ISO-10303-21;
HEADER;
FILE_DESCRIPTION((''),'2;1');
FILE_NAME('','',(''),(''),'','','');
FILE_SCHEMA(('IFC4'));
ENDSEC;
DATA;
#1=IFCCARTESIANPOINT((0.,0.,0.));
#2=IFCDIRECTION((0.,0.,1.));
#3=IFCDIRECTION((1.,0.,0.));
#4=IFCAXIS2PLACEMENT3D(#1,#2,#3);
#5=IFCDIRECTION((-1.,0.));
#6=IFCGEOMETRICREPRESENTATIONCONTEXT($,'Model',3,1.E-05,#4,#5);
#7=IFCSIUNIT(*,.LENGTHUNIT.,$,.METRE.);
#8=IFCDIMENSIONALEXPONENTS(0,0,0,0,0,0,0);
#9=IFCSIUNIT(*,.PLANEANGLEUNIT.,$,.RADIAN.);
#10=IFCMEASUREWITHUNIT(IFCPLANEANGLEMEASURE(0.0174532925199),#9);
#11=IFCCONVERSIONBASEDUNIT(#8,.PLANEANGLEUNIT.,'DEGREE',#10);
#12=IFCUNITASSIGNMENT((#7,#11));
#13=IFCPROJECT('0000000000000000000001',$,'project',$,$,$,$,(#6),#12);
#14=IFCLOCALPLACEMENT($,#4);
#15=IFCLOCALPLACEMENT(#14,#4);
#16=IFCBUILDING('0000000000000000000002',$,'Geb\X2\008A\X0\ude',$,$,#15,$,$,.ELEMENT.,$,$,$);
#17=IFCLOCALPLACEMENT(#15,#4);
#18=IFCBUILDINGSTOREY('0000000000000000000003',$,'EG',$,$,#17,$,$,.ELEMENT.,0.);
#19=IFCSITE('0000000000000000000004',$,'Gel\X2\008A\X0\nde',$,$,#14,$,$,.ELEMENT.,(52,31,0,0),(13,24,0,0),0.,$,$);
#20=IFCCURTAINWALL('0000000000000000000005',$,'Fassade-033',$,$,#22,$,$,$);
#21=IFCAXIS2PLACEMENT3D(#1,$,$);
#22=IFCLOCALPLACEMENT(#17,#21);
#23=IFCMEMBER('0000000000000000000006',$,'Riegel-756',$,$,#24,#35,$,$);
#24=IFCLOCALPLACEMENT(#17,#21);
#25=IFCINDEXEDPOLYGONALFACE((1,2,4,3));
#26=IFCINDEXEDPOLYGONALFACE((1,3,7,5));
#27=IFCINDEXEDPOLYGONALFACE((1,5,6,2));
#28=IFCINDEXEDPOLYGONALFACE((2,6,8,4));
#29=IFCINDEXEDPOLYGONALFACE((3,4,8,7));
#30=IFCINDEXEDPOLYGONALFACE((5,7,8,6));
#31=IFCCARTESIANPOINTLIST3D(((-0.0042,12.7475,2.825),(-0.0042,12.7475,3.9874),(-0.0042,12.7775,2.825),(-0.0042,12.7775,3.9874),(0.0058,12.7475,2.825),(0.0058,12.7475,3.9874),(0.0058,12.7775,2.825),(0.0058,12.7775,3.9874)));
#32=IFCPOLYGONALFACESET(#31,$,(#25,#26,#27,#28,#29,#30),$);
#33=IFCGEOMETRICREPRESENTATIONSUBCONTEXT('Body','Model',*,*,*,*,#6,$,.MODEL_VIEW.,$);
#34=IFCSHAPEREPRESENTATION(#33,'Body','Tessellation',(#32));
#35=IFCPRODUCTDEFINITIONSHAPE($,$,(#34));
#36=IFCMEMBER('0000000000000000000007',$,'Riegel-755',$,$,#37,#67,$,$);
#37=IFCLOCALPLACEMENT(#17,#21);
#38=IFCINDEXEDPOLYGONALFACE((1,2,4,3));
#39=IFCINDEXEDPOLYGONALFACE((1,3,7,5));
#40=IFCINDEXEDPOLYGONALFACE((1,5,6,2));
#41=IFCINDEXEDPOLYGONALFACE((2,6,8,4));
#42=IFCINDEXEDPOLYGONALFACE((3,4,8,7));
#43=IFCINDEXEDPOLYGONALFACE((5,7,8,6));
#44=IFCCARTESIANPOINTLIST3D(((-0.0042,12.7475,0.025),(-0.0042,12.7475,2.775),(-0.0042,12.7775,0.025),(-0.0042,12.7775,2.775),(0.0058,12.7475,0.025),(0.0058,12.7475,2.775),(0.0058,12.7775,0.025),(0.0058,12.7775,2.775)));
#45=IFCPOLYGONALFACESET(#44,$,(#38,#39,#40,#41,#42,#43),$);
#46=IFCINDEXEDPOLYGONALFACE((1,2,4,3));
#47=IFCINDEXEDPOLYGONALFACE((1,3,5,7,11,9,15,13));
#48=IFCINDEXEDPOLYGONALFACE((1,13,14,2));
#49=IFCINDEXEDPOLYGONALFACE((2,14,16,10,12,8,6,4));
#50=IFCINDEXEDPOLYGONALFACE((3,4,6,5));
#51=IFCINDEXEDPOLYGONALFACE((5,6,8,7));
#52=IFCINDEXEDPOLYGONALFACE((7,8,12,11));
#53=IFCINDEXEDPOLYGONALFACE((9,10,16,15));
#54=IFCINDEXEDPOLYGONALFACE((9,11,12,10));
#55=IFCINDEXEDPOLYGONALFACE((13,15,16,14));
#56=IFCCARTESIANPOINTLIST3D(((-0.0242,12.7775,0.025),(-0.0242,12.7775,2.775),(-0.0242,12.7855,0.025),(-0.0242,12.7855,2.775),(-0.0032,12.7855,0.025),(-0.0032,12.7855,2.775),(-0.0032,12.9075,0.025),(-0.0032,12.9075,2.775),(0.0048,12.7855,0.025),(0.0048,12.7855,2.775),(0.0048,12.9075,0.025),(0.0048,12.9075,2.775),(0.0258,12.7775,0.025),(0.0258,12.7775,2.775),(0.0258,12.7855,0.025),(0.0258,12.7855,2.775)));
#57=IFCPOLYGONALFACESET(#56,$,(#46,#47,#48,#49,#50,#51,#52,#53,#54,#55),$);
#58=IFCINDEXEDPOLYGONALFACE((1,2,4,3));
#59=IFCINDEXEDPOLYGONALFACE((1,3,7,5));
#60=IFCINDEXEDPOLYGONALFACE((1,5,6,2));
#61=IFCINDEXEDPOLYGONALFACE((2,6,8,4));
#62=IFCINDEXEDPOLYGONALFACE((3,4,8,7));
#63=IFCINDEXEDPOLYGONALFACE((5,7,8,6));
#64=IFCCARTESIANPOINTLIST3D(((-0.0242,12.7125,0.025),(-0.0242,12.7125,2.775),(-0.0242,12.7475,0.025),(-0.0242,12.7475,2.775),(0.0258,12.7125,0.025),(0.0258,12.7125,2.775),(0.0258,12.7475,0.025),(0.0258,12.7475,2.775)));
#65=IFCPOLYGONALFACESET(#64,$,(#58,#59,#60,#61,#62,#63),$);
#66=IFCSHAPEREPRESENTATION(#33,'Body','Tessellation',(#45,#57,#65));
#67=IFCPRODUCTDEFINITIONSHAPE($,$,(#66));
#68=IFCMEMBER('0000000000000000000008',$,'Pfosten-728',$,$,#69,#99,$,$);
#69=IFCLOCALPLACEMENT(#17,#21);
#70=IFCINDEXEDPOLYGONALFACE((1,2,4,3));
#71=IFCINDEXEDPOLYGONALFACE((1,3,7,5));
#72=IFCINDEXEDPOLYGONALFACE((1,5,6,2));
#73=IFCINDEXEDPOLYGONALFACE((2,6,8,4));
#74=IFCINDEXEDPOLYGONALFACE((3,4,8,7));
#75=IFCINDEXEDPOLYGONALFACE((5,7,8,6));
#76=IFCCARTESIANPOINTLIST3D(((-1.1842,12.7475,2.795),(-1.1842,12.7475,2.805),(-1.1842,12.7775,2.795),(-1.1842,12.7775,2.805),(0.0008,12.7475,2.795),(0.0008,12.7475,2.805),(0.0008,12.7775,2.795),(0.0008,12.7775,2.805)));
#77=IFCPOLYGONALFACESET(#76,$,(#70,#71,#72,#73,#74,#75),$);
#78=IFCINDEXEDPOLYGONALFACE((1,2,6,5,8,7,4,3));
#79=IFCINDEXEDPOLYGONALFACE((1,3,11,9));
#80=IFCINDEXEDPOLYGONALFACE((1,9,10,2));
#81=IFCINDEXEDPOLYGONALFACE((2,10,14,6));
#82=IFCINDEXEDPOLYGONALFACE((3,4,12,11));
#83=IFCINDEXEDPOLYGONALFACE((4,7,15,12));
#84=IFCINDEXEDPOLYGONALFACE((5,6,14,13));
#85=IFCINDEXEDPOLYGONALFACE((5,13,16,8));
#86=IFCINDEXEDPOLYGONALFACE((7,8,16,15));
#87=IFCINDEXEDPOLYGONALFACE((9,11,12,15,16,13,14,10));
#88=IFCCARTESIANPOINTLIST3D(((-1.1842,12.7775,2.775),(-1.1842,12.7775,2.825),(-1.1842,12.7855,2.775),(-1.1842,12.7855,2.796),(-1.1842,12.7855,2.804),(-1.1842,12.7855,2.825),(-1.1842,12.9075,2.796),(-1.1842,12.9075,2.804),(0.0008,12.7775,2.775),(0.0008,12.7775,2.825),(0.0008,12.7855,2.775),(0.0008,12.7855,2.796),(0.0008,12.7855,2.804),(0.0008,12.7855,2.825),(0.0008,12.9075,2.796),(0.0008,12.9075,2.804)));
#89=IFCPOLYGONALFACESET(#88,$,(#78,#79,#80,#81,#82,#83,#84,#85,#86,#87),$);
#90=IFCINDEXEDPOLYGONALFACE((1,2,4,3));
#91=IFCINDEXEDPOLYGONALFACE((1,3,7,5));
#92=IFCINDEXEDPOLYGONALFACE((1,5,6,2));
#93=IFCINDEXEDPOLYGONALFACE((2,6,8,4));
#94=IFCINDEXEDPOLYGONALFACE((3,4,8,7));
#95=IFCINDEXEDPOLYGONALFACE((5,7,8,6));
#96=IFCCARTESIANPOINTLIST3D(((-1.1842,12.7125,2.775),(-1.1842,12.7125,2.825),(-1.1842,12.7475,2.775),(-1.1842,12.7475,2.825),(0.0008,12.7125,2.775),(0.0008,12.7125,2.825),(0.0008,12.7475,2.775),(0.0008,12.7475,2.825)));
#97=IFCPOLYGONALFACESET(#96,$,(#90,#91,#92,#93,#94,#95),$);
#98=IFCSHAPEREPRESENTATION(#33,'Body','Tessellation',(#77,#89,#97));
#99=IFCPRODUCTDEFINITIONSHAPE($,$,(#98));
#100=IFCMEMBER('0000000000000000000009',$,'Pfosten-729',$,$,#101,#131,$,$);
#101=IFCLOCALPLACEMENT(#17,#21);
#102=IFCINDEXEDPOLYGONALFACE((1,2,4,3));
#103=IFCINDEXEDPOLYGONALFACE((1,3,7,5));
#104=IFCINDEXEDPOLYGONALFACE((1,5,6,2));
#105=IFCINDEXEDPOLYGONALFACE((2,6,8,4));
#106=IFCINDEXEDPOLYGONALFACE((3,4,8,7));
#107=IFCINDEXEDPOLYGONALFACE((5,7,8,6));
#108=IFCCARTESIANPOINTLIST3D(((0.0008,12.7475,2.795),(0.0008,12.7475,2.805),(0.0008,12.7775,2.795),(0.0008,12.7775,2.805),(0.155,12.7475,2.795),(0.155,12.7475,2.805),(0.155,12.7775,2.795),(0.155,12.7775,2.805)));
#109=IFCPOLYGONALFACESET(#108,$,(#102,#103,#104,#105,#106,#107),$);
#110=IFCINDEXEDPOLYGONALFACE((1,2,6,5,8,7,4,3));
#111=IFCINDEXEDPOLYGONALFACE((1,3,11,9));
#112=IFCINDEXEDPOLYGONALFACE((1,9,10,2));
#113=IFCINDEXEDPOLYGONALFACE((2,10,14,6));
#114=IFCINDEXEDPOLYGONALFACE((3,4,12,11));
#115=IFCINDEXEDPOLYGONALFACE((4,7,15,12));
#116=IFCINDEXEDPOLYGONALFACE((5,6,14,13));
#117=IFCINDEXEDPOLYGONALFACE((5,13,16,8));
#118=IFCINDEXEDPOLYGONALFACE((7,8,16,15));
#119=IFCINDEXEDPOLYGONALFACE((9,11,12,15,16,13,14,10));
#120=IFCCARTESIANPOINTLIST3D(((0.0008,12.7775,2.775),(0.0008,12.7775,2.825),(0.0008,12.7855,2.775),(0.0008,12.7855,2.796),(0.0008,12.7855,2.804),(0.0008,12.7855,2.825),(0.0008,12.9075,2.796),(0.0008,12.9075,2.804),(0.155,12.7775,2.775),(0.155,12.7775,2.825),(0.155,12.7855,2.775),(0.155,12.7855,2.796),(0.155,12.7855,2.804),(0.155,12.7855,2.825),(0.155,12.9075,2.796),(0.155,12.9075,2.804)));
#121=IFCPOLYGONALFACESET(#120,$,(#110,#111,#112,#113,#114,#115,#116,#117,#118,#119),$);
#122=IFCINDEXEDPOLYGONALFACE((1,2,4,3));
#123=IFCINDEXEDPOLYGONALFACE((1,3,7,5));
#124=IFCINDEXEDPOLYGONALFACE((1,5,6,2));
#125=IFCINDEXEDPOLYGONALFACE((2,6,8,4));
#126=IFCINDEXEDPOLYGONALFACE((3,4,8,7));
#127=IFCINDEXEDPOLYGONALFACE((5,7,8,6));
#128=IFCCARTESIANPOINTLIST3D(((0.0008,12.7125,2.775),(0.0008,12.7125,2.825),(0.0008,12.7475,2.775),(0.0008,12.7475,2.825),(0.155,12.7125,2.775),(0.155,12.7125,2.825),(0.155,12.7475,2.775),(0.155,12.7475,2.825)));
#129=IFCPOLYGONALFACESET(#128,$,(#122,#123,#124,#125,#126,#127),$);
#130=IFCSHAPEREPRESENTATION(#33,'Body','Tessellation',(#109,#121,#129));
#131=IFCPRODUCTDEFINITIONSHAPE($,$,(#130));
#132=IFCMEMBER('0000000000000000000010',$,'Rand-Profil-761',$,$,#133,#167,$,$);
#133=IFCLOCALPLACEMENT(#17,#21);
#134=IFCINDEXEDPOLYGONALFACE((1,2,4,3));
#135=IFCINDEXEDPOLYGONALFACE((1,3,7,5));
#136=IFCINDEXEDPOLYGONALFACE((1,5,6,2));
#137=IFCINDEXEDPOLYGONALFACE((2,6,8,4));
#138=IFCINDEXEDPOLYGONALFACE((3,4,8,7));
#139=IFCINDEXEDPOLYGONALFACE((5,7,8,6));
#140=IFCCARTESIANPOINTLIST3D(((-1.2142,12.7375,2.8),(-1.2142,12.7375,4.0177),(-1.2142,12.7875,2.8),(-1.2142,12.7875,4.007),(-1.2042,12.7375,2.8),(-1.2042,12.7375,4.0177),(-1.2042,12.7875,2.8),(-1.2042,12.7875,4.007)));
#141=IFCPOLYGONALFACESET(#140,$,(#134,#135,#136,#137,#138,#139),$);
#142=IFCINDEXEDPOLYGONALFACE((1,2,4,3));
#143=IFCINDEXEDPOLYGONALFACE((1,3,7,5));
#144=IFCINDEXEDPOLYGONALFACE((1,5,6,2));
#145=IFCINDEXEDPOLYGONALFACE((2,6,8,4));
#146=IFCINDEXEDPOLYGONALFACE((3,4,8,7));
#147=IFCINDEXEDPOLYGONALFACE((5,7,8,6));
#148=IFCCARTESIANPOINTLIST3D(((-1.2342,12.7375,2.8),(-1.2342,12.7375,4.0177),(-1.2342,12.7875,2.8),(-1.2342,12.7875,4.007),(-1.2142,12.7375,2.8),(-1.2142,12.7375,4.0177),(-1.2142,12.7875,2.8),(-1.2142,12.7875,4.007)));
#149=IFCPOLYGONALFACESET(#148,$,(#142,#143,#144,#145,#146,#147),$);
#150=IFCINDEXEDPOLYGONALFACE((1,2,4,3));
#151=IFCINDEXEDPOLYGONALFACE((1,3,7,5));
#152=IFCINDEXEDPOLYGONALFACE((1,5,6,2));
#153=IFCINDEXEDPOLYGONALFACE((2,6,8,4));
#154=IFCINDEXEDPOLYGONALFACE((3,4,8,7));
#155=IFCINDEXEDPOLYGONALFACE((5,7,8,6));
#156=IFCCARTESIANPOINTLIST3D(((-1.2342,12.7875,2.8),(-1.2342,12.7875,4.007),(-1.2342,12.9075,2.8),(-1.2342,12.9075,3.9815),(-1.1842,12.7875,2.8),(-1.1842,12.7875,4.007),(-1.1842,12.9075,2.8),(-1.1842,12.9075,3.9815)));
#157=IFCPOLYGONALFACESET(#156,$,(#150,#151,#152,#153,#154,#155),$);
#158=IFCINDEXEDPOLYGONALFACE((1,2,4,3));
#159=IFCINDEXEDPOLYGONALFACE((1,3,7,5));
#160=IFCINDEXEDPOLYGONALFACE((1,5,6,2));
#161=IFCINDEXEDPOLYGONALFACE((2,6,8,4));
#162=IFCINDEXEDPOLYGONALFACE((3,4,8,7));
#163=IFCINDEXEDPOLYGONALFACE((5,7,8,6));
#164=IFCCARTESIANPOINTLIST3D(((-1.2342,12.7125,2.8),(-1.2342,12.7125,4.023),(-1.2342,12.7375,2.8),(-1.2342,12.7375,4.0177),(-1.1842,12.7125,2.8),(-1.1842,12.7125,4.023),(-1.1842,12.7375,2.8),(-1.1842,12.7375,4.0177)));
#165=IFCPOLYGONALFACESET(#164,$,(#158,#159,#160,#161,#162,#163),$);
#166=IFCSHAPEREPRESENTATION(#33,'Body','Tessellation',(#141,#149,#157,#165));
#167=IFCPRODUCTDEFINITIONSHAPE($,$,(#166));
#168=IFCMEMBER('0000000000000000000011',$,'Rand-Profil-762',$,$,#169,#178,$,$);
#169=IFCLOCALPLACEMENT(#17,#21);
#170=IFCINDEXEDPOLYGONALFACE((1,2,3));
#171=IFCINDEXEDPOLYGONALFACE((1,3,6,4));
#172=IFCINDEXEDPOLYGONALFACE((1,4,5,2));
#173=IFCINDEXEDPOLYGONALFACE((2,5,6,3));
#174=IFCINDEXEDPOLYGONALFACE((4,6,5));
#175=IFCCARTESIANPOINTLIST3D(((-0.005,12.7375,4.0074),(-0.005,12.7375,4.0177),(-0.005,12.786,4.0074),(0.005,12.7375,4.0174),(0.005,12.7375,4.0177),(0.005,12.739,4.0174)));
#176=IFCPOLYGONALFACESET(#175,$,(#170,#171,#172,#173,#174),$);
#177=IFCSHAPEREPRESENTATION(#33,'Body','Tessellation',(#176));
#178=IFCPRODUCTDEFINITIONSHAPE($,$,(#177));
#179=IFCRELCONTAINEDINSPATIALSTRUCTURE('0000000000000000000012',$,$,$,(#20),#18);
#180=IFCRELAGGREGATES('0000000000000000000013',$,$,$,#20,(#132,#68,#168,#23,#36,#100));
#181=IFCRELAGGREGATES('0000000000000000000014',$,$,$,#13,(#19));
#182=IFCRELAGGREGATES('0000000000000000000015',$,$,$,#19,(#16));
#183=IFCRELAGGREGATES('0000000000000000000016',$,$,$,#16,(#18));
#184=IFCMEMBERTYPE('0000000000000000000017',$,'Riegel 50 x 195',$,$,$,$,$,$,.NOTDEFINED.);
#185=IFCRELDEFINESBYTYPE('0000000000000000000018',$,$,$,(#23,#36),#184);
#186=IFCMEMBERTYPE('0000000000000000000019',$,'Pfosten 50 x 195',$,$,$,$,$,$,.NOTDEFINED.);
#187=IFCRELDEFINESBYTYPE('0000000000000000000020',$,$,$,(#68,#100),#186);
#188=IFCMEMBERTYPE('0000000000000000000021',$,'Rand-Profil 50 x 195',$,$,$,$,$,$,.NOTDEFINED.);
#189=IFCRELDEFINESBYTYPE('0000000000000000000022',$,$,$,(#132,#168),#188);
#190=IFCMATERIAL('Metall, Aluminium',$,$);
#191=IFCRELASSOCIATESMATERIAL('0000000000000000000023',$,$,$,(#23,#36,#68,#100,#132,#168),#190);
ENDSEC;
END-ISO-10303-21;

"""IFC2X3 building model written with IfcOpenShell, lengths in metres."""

from ifc_helpers import new_model, entity, si_unit, converted_unit, direction, frame, origin_with_axes, place, context, subcontext, project, spatial, polyline, outline, extrude, clip, halfspace, material, type_object, element, aggregate, save


model = new_model("IFC2X3")

# Units and contexts
model_context = context("Model", 3, precision=1e-05, world=origin_with_axes(), true_north=direction((-1.0, 0.0)))
body_context = subcontext(model_context, "Body", "Model", "MODEL_VIEW")
ifc_project = project(units=[si_unit("LENGTHUNIT", "METRE"), converted_unit("PLANEANGLEUNIT", "DEGREE", entity("IfcPlaneAngleMeasure", 0.0174532925199), si_unit("PLANEANGLEUNIT", "RADIAN"), dimensions=[0, 0, 0, 0, 0, 0, 0])], contexts=[model_context])

# Site, building, storey
site_placement = place(None, origin_with_axes())
site = spatial("IfcSite", under=ifc_project, at=site_placement, Name="Gel\u008ande", CompositionType="ELEMENT", RefLatitude=(52, 31, 0, 0), RefLongitude=(13, 24, 0, 0), RefElevation=0.0)
building_placement = place(site_placement, origin_with_axes())
building = spatial("IfcBuilding", under=site, at=building_placement, Name="Geb\u008aude", CompositionType="ELEMENT")
storey_placement = place(building_placement, origin_with_axes())
storey = spatial("IfcBuildingStorey", under=building, at=storey_placement, Name="EG", CompositionType="ELEMENT", Elevation=0.0)

# Curtain wall, members
curtain_wall_placement = place(storey_placement, frame((-0.6042, 12.7625, 0.0), z_axis=(0.0, 0.0, 1.0), x_axis=(1.0, 0.0, 0.0)))
curtain_wall = element("IfcCurtainWall", 1, at=curtain_wall_placement, inside=storey, Name="Fassade-033")
ifc_material_1 = material(Name="Metall, Aluminium")
member_type_1 = type_object("IfcMemberType", Name="Riegel 50 x 195", PredefinedType="NOTDEFINED")
member_1_placement = place(curtain_wall_placement, frame((0.605, 0.0, 2.8), z_axis=(0.0, 0.0, 1.0), x_axis=(-1.0, 0.0, 0.0)))
member_1 = element("IfcMember", 2, at=member_1_placement, type_object=member_type_1, material=ifc_material_1, Name="Riegel-756", context=body_context, shape_type="SweptSolid", body=[
    extrude(outline(polyline([(-0.005, 0.015), (-0.005, -0.015), (0.005, -0.015), (0.005, 0.015), (-0.005, 0.015)])), frame((0.0, 0.0, 0.025), z_axis=(0.0, 0.0, 1.0), x_axis=(-1.0, 0.0, 0.0)), (0.0, 0.0, 1.0), 1.1624),
])
member_2_placement = place(curtain_wall_placement, frame((0.605, 0.0, 0.0), z_axis=(0.0, 0.0, 1.0), x_axis=(-1.0, 0.0, 0.0)))
member_2 = element("IfcMember", 3, at=member_2_placement, type_object=member_type_1, material=ifc_material_1, Name="Riegel-755", context=body_context, shape_type="SweptSolid", body=[
    extrude(outline(polyline([(-0.005, 0.015), (-0.005, -0.015), (0.005, -0.015), (0.005, 0.015), (-0.005, 0.015)])), frame((0.0, 0.0, 0.025), z_axis=(0.0, 0.0, 1.0), x_axis=(-1.0, 0.0, 0.0)), (0.0, 0.0, 1.0), 2.75),
    extrude(outline(polyline([(-0.004, 0.145), (-0.004, 0.023), (-0.025, 0.023), (-0.025, 0.015), (0.025, 0.015), (0.025, 0.023), (0.004, 0.023), (0.004, 0.145), (-0.004, 0.145)])), frame((0.0, 0.0, 0.025), z_axis=(0.0, 0.0, 1.0), x_axis=(-1.0, 0.0, 0.0)), (0.0, 0.0, 1.0), 2.75),
    extrude(outline(polyline([(0.025, -0.05), (0.025, -0.015), (-0.025, -0.015), (-0.025, -0.05), (0.025, -0.05)])), frame((0.0, 0.0, 0.025), z_axis=(0.0, 0.0, 1.0), x_axis=(-1.0, 0.0, 0.0)), (0.0, 0.0, 1.0), 2.75),
])
member_type_2 = type_object("IfcMemberType", Name="Pfosten 50 x 195", PredefinedType="NOTDEFINED")
member_3_placement = place(curtain_wall_placement, frame((-0.605, 0.0, 2.8), z_axis=(1.0, 0.0, 0.0), x_axis=(0.0, 0.0, 1.0)))
member_3 = element("IfcMember", 4, at=member_3_placement, type_object=member_type_2, material=ifc_material_1, Name="Pfosten-728", context=body_context, shape_type="SweptSolid", body=[
    extrude(outline(polyline([(-0.015, -0.005), (0.015, -0.005), (0.015, 0.005), (-0.015, 0.005), (-0.015, -0.005)])), frame((0.0, 0.0, 0.025), z_axis=(0.0, 0.0, 1.0), x_axis=(0.0, 1.0, 0.0)), (0.0, 0.0, 1.0), 1.185),
    extrude(outline(polyline([(-0.145, -0.004), (-0.023, -0.004), (-0.023, -0.025), (-0.015, -0.025), (-0.015, 0.025), (-0.023, 0.025), (-0.023, 0.004), (-0.145, 0.004), (-0.145, -0.004)])), frame((0.0, 0.0, 0.025), z_axis=(0.0, 0.0, 1.0), x_axis=(0.0, 1.0, 0.0)), (0.0, 0.0, 1.0), 1.185),
    extrude(outline(polyline([(0.05, 0.025), (0.015, 0.025), (0.015, -0.025), (0.05, -0.025), (0.05, 0.025)])), frame((0.0, 0.0, 0.025), z_axis=(0.0, 0.0, 1.0), x_axis=(0.0, 1.0, 0.0)), (0.0, 0.0, 1.0), 1.185),
])
member_4_placement = place(curtain_wall_placement, frame((0.605, 0.0, 2.8), z_axis=(1.0, 0.0, 0.0), x_axis=(0.0, 0.0, 1.0)))
member_4 = element("IfcMember", 5, at=member_4_placement, type_object=member_type_2, material=ifc_material_1, Name="Pfosten-729", context=body_context, shape_type="SweptSolid", body=[
    extrude(outline(polyline([(-0.015, -0.005), (0.015, -0.005), (0.015, 0.005), (-0.015, 0.005), (-0.015, -0.005)])), frame((0.0, 0.0, 0.0), z_axis=(0.0, 0.0, 1.0), x_axis=(0.0, 1.0, 0.0)), (0.0, 0.0, 1.0), 0.1542),
    extrude(outline(polyline([(-0.145, -0.004), (-0.023, -0.004), (-0.023, -0.025), (-0.015, -0.025), (-0.015, 0.025), (-0.023, 0.025), (-0.023, 0.004), (-0.145, 0.004), (-0.145, -0.004)])), frame((0.0, 0.0, 0.0), z_axis=(0.0, 0.0, 1.0), x_axis=(0.0, 1.0, 0.0)), (0.0, 0.0, 1.0), 0.1542),
    extrude(outline(polyline([(0.05, 0.025), (0.015, 0.025), (0.015, -0.025), (0.05, -0.025), (0.05, 0.025)])), frame((0.0, 0.0, 0.0), z_axis=(0.0, 0.0, 1.0), x_axis=(0.0, 1.0, 0.0)), (0.0, 0.0, 1.0), 0.1542),
])
member_type_3 = type_object("IfcMemberType", Name="Rand-Profil 50 x 195", PredefinedType="NOTDEFINED")
member_5_placement = place(curtain_wall_placement, frame((-0.605, 0.0, 2.8), z_axis=(0.0, 0.0, 1.0), x_axis=(-1.0, 0.0, 0.0)))
member_5 = element("IfcMember", 6, at=member_5_placement, type_object=member_type_3, material=ifc_material_1, Name="Rand-Profil-761", context=body_context, shape_type="Clipping", body=[
    clip(extrude(outline(polyline([(0.005, 0.025), (-0.005, 0.025), (-0.005, -0.025), (0.005, -0.025), (0.005, 0.025)])), frame((0.0, 0.0, 0.0), z_axis=(0.0, 0.0, 1.0), x_axis=(-1.0, 0.0, 0.0)), (0.0, 0.0, 1.0), 1.2177), halfspace(frame((0.0, -0.2466, 1.1599), z_axis=(0.0, 0.207912, -0.978148), x_axis=(0.0, -0.978148, -0.207912)), True)),
    clip(extrude(outline(polyline([(-0.005, 0.025), (-0.025, 0.025), (-0.025, -0.025), (-0.005, -0.025), (-0.005, 0.025)])), frame((0.0, 0.0, 0.0), z_axis=(0.0, 0.0, 1.0), x_axis=(-1.0, 0.0, 0.0)), (0.0, 0.0, 1.0), 1.2177), halfspace(frame((0.0, -0.2466, 1.1599), z_axis=(0.0, 0.207912, -0.978148), x_axis=(0.0, -0.978148, -0.207912)), True)),
    clip(extrude(outline(polyline([(0.025, 0.145), (-0.025, 0.145), (-0.025, 0.025), (0.025, 0.025), (0.025, 0.145)])), frame((0.0, 0.0, 0.0), z_axis=(0.0, 0.0, 1.0), x_axis=(-1.0, 0.0, 0.0)), (0.0, 0.0, 1.0), 1.207), halfspace(frame((0.0, -0.2466, 1.1599), z_axis=(0.0, 0.207912, -0.978148), x_axis=(0.0, -0.978148, -0.207912)), True)),
    clip(extrude(outline(polyline([(0.025, -0.025), (-0.025, -0.025), (-0.025, -0.05), (0.025, -0.05), (0.025, -0.025)])), frame((0.0, 0.0, 0.0), z_axis=(0.0, 0.0, 1.0), x_axis=(-1.0, 0.0, 0.0)), (0.0, 0.0, 1.0), 1.223), halfspace(frame((0.0, -0.2466, 1.1599), z_axis=(0.0, 0.207912, -0.978148), x_axis=(0.0, -0.978148, -0.207912)), True)),
])
member_6_placement = place(curtain_wall_placement, frame((0.6042, 0.0, 4.0124), z_axis=(0.0, 0.0, 1.0), x_axis=(-1.0, 0.0, 0.0)))
member_6 = element("IfcMember", 7, at=member_6_placement, type_object=member_type_3, material=ifc_material_1, Name="Rand-Profil-762", context=body_context, shape_type="Clipping", body=[
    clip(clip(extrude(outline(polyline([(0.005, -0.0235), (-0.005, 0.0235), (-0.005, -0.025), (0.005, -0.025), (0.005, -0.0235)])), frame((0.0, 0.0, -0.005), z_axis=(0.0, 0.0, 1.0), x_axis=(-1.0, 0.0, 0.0)), (0.0, 0.0, 1.0), 0.0103), halfspace(frame((0.0, 0.0, 0.0), z_axis=(0.707107, 0.0, 0.707107), x_axis=(-0.707107, 0.0, 0.707107)), True)), halfspace(frame((0.0, 0.0, 0.0), z_axis=(0.0, 0.207912, -0.978148), x_axis=(0.0, -0.978148, -0.207912)), True)),
])

aggregate(curtain_wall, [member_5, member_3, member_6, member_1, member_2, member_4])

save(model, "model.ifc")
